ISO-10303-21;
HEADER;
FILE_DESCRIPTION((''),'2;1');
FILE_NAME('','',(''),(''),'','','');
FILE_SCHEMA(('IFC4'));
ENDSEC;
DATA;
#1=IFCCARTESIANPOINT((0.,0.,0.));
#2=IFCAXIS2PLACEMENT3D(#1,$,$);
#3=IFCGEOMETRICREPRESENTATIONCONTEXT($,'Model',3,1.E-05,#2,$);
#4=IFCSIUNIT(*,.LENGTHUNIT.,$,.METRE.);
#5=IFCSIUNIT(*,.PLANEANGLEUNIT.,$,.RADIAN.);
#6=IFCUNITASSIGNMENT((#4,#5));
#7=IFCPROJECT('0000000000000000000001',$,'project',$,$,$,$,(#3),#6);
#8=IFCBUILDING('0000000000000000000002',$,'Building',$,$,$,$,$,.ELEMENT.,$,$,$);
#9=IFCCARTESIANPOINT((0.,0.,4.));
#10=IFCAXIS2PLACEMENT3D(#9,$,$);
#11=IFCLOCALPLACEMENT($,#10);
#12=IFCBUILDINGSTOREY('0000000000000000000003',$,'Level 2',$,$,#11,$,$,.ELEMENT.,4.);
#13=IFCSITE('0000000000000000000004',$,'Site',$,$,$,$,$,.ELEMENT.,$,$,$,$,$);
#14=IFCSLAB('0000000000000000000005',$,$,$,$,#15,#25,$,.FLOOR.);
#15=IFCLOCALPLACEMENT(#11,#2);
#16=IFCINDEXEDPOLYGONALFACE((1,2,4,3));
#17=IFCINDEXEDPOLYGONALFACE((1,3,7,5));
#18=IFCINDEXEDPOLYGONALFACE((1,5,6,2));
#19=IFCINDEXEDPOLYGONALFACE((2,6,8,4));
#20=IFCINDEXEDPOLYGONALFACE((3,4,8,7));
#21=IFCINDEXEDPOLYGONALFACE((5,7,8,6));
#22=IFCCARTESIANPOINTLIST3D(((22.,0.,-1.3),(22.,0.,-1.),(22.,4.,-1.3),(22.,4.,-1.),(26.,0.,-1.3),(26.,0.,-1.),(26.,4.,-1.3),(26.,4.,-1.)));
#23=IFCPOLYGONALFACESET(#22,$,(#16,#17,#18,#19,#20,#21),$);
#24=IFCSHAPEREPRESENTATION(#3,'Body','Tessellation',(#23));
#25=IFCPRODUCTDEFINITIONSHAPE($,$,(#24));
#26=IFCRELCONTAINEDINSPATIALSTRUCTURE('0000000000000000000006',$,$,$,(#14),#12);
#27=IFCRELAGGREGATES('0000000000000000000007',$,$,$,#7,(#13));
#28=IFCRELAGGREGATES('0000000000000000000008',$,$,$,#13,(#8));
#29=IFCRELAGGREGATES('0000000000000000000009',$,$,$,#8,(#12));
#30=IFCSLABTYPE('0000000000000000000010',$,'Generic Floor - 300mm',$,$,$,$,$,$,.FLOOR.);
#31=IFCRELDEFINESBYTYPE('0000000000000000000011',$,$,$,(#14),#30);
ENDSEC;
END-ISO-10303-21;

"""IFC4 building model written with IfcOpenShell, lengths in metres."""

from ifc_helpers import new_model, si_unit, frame, origin, place, context, project, spatial, polyline, outline, extrude, type_object, element, save


model = new_model("IFC4")

# Units and contexts
model_context = context("Model", 3, precision=1e-05, world=origin())
ifc_project = project(units=[si_unit("LENGTHUNIT", "METRE"), si_unit("PLANEANGLEUNIT", "RADIAN")], contexts=[model_context])

# Site, building, storey
site = spatial("IfcSite", under=ifc_project, Name="Site", CompositionType="ELEMENT")
building = spatial("IfcBuilding", under=site, Name="Building", CompositionType="ELEMENT")
storey_placement = place(None, frame((0.0, 0.0, 4.0)))
storey = spatial("IfcBuildingStorey", under=building, at=storey_placement, Name="Level 2", CompositionType="ELEMENT", Elevation=4.0)

# Slab
slab_type = type_object("IfcSlabType", Name="Generic Floor - 300mm", PredefinedType="FLOOR")
slab_placement = place(None, frame((0.0, 0.0, 3.0)))
element("IfcSlab", 1, at=slab_placement, inside=storey, type_object=slab_type, PredefinedType="FLOOR", context=model_context, shape_type="SweptSolid", body=[
    extrude(outline(polyline([(22.0, 0.0), (26.0, 0.0), (26.0, 4.0), (22.0, 4.0), (22.0, 0.0)])), origin(), (0.0, 0.0, -1.0), 0.3),
])

save(model, "model.ifc")
